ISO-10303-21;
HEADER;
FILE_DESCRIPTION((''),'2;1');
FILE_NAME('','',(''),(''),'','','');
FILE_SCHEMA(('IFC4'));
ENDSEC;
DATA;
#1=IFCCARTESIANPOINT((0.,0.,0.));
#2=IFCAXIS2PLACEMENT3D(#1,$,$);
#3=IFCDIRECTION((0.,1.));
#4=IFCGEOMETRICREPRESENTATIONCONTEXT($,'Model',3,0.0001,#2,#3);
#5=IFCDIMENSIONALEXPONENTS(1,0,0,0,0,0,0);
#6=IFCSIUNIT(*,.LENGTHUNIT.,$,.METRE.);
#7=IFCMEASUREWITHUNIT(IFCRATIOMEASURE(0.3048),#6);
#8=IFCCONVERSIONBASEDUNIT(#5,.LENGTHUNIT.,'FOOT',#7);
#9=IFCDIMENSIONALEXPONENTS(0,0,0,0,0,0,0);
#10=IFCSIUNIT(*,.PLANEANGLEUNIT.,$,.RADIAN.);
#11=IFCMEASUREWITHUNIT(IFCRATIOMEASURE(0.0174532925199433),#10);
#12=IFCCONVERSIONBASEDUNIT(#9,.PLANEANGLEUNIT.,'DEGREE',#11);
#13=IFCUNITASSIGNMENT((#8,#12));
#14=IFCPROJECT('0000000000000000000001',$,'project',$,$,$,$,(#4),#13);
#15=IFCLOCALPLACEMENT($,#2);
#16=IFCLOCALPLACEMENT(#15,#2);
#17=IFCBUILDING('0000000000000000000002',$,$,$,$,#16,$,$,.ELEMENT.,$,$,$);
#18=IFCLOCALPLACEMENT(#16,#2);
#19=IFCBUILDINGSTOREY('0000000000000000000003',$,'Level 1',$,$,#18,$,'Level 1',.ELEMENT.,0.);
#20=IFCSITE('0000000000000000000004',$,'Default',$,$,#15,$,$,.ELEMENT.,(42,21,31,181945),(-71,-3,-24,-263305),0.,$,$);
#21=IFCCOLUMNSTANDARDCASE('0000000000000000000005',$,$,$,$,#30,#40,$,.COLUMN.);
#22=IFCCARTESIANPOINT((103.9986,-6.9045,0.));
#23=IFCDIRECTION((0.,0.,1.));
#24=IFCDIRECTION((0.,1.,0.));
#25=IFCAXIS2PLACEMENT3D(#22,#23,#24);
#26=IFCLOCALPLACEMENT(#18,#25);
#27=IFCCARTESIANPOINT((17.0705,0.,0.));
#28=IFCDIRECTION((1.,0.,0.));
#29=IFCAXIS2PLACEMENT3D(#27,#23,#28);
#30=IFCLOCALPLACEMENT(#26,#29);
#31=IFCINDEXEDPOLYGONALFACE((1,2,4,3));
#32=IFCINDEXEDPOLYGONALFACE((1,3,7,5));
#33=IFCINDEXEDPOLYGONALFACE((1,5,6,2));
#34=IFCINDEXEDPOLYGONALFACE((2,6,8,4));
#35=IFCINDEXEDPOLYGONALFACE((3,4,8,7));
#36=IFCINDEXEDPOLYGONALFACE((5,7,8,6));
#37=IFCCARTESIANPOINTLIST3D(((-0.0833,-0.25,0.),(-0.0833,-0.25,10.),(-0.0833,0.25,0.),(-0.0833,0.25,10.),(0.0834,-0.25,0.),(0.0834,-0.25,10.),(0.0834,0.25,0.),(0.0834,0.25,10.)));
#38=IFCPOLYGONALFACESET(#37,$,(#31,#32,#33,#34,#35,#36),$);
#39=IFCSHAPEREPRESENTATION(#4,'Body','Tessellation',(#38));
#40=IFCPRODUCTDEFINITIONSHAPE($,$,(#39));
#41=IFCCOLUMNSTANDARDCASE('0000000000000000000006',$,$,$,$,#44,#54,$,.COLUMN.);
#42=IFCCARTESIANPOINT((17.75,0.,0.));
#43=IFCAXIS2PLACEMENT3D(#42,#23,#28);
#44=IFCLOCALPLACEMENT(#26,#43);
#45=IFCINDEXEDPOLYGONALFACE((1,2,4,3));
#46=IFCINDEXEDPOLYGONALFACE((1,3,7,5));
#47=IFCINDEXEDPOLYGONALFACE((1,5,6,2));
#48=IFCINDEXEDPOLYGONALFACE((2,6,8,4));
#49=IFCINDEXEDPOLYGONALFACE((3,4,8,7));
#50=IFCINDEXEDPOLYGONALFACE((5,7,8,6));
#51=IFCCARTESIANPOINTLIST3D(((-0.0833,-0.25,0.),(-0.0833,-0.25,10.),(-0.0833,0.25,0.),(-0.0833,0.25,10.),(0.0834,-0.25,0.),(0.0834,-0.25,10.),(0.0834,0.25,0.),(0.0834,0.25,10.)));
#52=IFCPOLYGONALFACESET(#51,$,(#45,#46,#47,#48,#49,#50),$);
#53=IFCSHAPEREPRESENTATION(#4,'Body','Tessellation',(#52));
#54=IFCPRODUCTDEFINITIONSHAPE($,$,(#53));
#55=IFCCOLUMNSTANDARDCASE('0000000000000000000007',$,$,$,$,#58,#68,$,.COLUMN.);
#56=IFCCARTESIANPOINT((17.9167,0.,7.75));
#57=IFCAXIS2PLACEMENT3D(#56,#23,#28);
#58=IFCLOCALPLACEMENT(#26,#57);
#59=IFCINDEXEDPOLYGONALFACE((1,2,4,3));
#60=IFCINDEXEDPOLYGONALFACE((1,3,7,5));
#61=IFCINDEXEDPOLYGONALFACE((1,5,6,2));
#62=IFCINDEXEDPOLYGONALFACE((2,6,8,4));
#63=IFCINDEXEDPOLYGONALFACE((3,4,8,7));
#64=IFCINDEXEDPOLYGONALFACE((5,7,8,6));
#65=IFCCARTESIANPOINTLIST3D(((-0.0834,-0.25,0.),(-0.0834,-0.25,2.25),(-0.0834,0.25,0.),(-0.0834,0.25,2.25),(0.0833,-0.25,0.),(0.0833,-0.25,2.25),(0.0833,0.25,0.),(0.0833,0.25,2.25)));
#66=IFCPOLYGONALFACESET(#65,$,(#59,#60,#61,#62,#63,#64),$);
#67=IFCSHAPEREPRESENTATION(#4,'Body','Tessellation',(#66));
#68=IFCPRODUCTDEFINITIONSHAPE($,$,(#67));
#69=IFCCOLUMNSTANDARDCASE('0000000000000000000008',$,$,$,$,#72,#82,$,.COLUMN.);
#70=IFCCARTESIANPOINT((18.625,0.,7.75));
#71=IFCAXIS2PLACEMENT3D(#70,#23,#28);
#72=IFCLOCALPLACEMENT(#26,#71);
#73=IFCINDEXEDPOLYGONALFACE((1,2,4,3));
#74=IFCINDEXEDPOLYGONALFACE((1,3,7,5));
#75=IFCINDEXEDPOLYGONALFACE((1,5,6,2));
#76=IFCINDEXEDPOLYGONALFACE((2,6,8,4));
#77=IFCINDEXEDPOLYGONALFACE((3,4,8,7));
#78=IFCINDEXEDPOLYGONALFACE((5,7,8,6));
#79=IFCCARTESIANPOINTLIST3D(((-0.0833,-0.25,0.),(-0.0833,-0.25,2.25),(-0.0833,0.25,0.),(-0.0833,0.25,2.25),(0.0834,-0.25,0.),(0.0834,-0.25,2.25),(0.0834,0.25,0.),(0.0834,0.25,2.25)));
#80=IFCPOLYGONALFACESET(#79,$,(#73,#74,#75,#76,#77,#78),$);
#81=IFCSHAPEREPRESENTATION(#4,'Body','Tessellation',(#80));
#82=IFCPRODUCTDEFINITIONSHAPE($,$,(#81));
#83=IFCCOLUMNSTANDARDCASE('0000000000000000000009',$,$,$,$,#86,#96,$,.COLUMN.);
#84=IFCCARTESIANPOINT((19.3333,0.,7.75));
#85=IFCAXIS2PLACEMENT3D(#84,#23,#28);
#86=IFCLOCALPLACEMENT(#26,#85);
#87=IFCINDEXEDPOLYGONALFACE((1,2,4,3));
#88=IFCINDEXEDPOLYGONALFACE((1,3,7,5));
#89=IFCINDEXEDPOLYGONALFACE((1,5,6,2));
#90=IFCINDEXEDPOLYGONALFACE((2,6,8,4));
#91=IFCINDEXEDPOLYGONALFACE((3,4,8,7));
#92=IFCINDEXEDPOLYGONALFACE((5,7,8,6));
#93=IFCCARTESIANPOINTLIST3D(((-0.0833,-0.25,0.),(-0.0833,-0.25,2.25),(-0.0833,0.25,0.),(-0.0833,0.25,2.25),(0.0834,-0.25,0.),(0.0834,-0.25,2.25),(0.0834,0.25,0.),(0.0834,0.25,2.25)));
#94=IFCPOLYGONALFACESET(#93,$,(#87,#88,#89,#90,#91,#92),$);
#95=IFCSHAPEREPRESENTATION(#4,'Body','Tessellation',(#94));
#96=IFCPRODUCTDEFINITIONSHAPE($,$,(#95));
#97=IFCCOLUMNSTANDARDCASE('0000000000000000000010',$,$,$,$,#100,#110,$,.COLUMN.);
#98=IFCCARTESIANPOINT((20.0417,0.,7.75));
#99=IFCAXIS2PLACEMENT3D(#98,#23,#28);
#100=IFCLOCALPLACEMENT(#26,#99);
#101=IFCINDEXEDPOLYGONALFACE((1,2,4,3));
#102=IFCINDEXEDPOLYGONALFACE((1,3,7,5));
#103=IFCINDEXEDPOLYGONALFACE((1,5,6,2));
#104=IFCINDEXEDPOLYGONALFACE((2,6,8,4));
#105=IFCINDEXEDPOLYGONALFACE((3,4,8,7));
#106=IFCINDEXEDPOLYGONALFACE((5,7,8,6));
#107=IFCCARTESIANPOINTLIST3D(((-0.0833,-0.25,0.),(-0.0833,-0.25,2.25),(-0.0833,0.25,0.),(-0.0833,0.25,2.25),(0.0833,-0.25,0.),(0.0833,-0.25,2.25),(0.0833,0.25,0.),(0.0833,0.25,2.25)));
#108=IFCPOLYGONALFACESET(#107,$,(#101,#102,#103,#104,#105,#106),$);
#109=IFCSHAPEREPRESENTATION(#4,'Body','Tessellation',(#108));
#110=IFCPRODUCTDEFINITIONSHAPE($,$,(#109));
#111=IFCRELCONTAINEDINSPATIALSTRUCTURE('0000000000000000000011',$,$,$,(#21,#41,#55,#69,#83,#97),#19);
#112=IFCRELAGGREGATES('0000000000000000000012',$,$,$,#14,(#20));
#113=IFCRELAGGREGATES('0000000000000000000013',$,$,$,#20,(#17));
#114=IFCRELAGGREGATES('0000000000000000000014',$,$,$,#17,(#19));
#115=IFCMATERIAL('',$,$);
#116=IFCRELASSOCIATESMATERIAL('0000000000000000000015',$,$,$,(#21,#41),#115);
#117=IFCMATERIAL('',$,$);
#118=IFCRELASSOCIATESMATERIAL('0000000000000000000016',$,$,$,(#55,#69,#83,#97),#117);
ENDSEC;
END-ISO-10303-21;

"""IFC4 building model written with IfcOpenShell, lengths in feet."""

from ifc_helpers import new_model, entity, si_unit, converted_unit, direction, frame, origin, place, context, project, spatial, rectangle, extrude, material, element, save


model = new_model("IFC4")

# Units and contexts
model_context = context("Model", 3, precision=0.0001, world=origin(), true_north=direction((0.0, 1.0)))
ifc_project = project(units=[converted_unit("LENGTHUNIT", "FOOT", entity("IfcRatioMeasure", 0.3048), si_unit("LENGTHUNIT", "METRE"), dimensions=[1, 0, 0, 0, 0, 0, 0]), converted_unit("PLANEANGLEUNIT", "DEGREE", entity("IfcRatioMeasure", 0.0174532925199433), si_unit("PLANEANGLEUNIT", "RADIAN"), dimensions=[0, 0, 0, 0, 0, 0, 0])], contexts=[model_context])

# Site, building, storey
site_placement = place(None, origin())
site = spatial("IfcSite", under=ifc_project, at=site_placement, Name="Default", CompositionType="ELEMENT", RefLatitude=(42, 21, 31, 181945), RefLongitude=(-71, -3, -24, -263305), RefElevation=0.0)
building_placement = place(site_placement, origin())
building = spatial("IfcBuilding", under=site, at=building_placement, CompositionType="ELEMENT")
storey_placement = place(building_placement, origin())
storey = spatial("IfcBuildingStorey", under=building, at=storey_placement, Name="Level 1", LongName="Level 1", CompositionType="ELEMENT", Elevation=0.0)

# Columns
ifc_material_1 = material(Name="")
placement = place(storey_placement, frame((103.9986, -6.9045, 0.0), z_axis=(0.0, 0.0, 1.0), x_axis=(0.0, 1.0, 0.0)))
for number, where, z_axis, x_axis in (
    (1, (17.0705, 0.0, 0.0), (0.0, 0.0, 1.0), (1.0, 0.0, 0.0)),
    (2, (17.75, 0.0, 0.0), (0.0, 0.0, 1.0), (1.0, 0.0, 0.0)),
):
    element("IfcColumnStandardCase", number, at=place(placement, frame(where, z_axis=z_axis, x_axis=x_axis)), inside=storey, material=ifc_material_1, PredefinedType="COLUMN", context=model_context, shape_type="SweptSolid", body=[
        extrude(rectangle(XDim=0.1667, YDim=0.5), origin(), (0.0, 0.0, 1.0), 10.0),
    ])
ifc_material_2 = material(Name="")
for number, where, z_axis, x_axis in (
    (3, (17.9167, 0.0, 7.75), (0.0, 0.0, 1.0), (1.0, 0.0, 0.0)),
    (4, (18.625, 0.0, 7.75), (0.0, 0.0, 1.0), (1.0, 0.0, 0.0)),
    (5, (19.3333, 0.0, 7.75), (0.0, 0.0, 1.0), (1.0, 0.0, 0.0)),
    (6, (20.0417, 0.0, 7.75), (0.0, 0.0, 1.0), (1.0, 0.0, 0.0)),
):
    element("IfcColumnStandardCase", number, at=place(placement, frame(where, z_axis=z_axis, x_axis=x_axis)), inside=storey, material=ifc_material_2, PredefinedType="COLUMN", context=model_context, shape_type="SweptSolid", body=[
        extrude(rectangle(XDim=0.1667, YDim=0.5), origin(), (0.0, 0.0, 1.0), 2.25),
    ])

save(model, "model.ifc")
